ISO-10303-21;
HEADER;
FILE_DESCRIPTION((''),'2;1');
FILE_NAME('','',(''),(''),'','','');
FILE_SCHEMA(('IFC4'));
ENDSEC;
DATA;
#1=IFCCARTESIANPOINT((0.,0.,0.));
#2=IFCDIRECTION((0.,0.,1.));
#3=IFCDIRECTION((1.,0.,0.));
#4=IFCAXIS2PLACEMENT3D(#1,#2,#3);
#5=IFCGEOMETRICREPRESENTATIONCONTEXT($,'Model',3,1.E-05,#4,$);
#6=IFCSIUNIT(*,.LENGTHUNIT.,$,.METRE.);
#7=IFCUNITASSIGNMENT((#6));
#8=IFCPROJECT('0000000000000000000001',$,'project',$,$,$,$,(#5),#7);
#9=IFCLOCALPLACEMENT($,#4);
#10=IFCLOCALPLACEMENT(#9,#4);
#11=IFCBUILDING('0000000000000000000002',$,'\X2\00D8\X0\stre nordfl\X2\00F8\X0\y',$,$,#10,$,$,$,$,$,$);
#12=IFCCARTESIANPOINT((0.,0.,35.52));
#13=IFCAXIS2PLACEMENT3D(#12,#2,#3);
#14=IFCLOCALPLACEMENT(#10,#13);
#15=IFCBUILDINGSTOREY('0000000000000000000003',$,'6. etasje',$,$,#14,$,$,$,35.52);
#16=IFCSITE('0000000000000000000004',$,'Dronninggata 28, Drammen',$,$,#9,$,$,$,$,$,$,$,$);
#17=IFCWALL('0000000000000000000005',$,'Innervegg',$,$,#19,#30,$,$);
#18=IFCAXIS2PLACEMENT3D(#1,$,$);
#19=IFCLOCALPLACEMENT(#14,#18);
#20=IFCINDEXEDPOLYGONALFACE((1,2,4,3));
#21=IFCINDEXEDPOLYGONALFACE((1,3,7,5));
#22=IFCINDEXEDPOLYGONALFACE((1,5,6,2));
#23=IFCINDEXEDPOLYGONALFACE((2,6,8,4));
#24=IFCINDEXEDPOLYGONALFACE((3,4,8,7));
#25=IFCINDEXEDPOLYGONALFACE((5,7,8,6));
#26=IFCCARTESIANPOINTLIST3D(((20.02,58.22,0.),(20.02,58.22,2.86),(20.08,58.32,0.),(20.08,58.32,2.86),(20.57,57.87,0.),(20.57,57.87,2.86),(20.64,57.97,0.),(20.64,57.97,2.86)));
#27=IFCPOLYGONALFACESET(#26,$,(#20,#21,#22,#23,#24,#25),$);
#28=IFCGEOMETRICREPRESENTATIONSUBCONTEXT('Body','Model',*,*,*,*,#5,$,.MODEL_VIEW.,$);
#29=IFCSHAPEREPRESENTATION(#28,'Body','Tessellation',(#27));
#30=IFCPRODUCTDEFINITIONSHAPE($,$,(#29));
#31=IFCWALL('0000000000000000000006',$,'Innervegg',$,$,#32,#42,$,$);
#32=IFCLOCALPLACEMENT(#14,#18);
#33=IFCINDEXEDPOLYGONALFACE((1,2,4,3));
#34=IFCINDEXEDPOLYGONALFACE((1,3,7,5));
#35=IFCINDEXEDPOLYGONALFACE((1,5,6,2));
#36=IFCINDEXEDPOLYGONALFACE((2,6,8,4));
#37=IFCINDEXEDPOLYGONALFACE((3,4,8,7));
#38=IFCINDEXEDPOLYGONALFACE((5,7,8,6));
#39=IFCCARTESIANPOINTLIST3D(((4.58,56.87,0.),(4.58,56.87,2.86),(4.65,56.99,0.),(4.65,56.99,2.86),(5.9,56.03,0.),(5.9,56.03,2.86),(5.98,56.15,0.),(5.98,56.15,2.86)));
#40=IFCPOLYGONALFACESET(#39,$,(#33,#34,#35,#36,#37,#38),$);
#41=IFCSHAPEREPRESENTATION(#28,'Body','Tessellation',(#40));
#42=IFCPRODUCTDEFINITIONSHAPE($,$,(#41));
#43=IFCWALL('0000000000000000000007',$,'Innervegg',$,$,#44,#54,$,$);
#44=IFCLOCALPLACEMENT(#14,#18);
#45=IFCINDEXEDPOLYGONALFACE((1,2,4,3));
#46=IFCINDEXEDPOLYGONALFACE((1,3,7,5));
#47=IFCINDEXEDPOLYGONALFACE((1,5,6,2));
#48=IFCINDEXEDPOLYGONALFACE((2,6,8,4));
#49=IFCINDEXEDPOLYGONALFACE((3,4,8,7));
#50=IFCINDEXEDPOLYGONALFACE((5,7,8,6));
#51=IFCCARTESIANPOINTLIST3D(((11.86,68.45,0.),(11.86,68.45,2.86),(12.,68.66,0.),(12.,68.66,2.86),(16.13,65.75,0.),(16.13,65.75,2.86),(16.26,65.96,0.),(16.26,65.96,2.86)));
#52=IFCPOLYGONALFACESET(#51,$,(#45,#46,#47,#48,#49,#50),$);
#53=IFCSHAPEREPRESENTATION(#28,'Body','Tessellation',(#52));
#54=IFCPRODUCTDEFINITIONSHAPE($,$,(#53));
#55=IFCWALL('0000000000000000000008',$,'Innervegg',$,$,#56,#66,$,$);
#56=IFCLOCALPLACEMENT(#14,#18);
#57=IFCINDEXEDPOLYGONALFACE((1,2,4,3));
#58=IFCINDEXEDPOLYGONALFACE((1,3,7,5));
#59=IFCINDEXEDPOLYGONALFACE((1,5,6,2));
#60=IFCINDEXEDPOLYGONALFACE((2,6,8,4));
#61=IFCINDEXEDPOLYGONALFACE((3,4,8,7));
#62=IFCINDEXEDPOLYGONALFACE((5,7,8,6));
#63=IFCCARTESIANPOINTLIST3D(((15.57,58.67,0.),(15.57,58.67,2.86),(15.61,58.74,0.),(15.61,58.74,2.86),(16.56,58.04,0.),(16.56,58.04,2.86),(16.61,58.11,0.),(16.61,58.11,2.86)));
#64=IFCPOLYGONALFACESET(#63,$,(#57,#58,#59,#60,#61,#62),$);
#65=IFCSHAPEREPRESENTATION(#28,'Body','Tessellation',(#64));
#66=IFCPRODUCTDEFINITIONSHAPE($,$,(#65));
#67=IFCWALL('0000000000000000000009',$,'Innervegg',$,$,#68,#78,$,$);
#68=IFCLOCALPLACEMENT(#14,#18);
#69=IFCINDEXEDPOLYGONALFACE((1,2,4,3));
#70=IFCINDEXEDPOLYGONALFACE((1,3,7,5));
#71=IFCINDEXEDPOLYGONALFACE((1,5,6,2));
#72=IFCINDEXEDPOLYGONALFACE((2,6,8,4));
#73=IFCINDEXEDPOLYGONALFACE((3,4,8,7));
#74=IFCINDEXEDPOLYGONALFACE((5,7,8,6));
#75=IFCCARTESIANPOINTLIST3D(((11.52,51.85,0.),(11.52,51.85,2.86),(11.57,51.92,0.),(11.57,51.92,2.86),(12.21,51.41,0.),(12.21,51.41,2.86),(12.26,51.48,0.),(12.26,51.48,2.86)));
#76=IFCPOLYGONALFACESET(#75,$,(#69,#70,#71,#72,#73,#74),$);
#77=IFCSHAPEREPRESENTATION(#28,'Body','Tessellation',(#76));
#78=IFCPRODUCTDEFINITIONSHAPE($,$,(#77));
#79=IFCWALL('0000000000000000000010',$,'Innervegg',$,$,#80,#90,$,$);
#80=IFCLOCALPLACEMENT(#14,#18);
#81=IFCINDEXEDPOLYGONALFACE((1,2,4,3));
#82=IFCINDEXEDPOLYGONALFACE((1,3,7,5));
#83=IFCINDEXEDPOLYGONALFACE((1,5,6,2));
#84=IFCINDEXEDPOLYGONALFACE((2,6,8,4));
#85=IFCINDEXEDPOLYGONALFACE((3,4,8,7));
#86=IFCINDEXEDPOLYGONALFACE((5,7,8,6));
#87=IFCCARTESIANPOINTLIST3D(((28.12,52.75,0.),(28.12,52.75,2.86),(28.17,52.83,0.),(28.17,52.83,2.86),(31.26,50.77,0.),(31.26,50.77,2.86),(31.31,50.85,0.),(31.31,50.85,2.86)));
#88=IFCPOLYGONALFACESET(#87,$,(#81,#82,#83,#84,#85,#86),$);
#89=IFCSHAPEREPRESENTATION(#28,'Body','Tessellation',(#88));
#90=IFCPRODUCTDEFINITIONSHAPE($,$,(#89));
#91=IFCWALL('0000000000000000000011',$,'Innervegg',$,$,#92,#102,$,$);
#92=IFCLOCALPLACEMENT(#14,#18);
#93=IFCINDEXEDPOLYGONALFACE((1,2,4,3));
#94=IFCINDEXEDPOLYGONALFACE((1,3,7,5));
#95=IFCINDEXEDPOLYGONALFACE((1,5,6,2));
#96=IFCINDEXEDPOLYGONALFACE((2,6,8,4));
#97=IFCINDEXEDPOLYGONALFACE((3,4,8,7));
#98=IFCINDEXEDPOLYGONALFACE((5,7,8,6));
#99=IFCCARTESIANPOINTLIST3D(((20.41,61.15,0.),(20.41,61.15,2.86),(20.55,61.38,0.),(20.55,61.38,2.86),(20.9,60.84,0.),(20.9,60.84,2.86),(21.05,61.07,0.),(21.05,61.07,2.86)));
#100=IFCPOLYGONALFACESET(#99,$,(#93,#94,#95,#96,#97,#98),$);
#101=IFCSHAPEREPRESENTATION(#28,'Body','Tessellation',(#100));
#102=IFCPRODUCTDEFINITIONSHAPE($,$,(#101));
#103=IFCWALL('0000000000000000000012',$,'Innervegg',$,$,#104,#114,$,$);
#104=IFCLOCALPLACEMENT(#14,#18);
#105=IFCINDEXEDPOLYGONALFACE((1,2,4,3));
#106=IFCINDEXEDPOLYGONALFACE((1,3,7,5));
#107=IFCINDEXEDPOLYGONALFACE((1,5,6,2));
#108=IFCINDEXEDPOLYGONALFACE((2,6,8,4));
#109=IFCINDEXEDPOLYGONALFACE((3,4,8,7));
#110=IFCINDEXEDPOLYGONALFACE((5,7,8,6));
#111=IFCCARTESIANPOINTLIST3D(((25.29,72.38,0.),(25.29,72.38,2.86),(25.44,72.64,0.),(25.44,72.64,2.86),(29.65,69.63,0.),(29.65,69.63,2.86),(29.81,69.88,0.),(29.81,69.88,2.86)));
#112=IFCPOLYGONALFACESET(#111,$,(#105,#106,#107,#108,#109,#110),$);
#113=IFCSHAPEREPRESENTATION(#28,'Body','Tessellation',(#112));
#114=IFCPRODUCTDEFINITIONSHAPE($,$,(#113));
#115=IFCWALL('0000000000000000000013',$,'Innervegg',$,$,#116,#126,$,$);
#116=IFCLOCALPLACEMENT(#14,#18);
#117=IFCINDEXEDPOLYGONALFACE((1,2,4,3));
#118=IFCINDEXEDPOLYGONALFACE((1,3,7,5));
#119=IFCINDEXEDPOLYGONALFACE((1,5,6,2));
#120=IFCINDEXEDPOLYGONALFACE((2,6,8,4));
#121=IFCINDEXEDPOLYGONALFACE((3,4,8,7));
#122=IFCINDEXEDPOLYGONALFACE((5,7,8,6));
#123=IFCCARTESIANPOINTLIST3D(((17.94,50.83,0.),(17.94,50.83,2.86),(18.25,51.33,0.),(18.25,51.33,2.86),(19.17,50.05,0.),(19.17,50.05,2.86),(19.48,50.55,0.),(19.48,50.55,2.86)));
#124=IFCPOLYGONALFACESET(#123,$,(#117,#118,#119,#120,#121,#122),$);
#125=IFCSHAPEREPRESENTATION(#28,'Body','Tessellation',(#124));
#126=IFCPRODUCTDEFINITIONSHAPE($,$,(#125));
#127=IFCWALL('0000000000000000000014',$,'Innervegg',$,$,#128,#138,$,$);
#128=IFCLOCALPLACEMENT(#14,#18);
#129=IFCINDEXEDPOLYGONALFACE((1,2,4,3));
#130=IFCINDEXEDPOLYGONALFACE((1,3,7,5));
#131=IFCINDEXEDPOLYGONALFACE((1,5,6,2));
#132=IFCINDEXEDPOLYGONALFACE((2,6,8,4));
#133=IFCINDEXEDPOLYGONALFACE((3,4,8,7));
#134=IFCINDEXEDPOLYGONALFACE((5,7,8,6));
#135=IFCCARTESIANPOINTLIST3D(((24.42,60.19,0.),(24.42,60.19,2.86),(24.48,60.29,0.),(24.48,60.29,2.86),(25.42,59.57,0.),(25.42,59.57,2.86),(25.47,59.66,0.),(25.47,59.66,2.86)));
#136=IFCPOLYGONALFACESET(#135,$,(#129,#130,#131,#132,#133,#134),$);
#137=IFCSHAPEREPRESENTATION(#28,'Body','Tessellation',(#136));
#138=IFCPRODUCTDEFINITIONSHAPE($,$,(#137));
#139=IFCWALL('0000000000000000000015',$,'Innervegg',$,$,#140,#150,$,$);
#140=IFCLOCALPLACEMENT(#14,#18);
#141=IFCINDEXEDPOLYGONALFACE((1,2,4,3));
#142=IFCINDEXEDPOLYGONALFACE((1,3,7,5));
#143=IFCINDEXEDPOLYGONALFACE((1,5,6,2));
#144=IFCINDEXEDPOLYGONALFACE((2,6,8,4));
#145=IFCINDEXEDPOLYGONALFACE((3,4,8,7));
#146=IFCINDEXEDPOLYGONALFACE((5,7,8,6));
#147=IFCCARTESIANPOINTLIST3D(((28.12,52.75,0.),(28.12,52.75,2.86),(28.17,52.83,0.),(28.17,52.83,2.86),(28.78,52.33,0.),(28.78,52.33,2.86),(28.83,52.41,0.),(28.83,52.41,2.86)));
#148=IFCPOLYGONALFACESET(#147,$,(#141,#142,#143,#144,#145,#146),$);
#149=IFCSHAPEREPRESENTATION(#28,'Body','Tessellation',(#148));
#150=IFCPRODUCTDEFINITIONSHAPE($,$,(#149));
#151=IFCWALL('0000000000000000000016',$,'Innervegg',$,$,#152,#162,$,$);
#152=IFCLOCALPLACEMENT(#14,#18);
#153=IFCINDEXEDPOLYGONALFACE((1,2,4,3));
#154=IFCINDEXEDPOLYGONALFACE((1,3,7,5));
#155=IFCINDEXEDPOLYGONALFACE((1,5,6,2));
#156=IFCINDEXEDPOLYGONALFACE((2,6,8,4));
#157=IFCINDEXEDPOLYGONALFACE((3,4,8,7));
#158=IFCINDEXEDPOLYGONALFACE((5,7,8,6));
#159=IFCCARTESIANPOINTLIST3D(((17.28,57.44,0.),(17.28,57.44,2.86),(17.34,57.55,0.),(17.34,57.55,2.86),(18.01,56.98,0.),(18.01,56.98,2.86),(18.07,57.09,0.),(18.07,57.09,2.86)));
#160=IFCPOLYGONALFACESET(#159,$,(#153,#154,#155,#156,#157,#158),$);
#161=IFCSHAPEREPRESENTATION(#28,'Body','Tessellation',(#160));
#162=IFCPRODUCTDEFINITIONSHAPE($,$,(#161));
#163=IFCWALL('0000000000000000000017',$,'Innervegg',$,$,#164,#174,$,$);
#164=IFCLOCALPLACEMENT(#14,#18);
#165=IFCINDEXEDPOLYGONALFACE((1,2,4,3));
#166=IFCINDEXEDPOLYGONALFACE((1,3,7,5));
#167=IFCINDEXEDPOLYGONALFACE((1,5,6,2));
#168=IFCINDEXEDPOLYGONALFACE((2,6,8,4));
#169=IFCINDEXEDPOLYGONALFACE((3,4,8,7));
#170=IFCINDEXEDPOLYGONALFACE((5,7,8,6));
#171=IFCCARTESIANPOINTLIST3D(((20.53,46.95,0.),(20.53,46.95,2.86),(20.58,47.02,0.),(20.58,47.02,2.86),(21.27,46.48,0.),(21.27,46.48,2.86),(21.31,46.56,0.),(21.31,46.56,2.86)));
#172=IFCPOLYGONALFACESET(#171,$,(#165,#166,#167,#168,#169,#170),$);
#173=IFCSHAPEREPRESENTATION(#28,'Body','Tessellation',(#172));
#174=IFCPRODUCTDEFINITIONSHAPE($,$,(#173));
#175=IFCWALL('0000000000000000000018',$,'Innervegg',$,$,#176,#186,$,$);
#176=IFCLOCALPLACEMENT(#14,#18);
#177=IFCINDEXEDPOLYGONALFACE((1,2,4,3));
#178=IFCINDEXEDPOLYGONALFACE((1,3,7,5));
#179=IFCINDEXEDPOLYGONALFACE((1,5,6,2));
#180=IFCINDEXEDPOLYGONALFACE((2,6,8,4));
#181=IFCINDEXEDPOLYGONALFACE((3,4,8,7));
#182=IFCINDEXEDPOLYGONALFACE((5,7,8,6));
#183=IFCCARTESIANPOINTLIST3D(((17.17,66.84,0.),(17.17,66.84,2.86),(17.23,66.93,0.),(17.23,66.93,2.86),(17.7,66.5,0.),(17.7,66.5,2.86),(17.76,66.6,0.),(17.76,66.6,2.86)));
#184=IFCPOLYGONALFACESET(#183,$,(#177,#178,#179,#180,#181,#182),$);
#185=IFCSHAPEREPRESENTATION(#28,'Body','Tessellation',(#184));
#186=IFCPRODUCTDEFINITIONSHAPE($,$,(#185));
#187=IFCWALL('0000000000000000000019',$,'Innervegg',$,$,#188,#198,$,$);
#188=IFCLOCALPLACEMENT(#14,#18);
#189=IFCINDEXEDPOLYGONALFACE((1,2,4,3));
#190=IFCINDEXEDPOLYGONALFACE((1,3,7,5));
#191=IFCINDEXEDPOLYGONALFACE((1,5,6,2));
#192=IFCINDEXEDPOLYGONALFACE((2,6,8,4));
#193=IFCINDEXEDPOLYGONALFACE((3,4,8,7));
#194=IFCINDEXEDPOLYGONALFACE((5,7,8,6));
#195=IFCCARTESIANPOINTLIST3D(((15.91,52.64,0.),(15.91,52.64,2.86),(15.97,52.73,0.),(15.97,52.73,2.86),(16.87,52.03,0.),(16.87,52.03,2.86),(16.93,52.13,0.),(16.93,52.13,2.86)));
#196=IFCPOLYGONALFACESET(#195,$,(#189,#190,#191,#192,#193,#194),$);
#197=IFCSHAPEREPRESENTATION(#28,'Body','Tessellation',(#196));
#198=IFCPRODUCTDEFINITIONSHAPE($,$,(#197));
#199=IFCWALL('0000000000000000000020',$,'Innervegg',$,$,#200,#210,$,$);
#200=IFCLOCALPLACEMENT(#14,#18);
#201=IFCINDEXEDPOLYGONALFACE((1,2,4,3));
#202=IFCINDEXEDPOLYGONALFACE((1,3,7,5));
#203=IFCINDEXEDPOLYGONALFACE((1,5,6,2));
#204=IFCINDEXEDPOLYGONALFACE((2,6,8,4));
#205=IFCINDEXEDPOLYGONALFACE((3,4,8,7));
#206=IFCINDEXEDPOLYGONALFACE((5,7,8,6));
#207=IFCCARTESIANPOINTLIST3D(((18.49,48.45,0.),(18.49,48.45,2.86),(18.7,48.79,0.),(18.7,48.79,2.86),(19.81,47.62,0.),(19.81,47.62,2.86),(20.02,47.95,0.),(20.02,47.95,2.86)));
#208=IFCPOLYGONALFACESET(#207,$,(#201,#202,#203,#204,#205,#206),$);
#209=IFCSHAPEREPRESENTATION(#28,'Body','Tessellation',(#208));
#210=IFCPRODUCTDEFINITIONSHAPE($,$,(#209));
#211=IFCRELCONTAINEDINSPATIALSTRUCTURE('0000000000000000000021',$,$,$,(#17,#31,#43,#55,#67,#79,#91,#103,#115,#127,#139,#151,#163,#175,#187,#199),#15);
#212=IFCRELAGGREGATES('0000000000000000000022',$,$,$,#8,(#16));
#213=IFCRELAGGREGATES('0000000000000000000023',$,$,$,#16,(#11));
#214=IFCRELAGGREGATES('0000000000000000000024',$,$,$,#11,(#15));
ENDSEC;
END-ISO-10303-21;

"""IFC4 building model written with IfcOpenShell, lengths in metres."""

from ifc_helpers import new_model, si_unit, frame, origin_with_axes, place, context, subcontext, project, spatial, polyline, outline, extrude, element, save


model = new_model("IFC4")

# Units and contexts
model_context = context("Model", 3, precision=1e-05, world=origin_with_axes())
body_context = subcontext(model_context, "Body", "Model", "MODEL_VIEW")
ifc_project = project(units=[si_unit("LENGTHUNIT", "METRE")], contexts=[model_context])

# Site, building, storey
site_placement = place(None, origin_with_axes())
site = spatial("IfcSite", under=ifc_project, at=site_placement, Name="Dronninggata 28, Drammen")
building_placement = place(site_placement, origin_with_axes())
building = spatial("IfcBuilding", under=site, at=building_placement, Name="Østre nordfløy")
storey_placement = place(building_placement, frame((0.0, 0.0, 35.52), z_axis=(0.0, 0.0, 1.0), x_axis=(1.0, 0.0, 0.0)))
storey = spatial("IfcBuildingStorey", under=building, at=storey_placement, Name="6. etasje", Elevation=35.52)

# Walls
wall_1_placement = place(storey_placement, frame((0.0, 0.0, -35.52), z_axis=(0.0, 0.0, 1.0), x_axis=(1.0, 0.0, 0.0)))
element("IfcWall", 1, at=wall_1_placement, inside=storey, Name="Innervegg", context=body_context, shape_type="SweptSolid", body=[
    extrude(outline(polyline([(20.64, 57.97), (20.57, 57.87), (20.02, 58.22), (20.08, 58.32), (20.64, 57.97)])), frame((0.0, 0.0, 35.52)), (0.0, 0.0, 1.0), 2.86),
])
wall_2_placement = place(storey_placement, frame((0.0, 0.0, -35.52), z_axis=(0.0, 0.0, 1.0), x_axis=(1.0, 0.0, 0.0)))
element("IfcWall", 2, at=wall_2_placement, inside=storey, Name="Innervegg", context=body_context, shape_type="SweptSolid", body=[
    extrude(outline(polyline([(5.98, 56.15), (5.9, 56.03), (4.58, 56.87), (4.65, 56.99), (5.98, 56.15)])), frame((0.0, 0.0, 35.52)), (0.0, 0.0, 1.0), 2.86),
])
wall_3_placement = place(storey_placement, frame((0.0, 0.0, -35.52), z_axis=(0.0, 0.0, 1.0), x_axis=(1.0, 0.0, 0.0)))
element("IfcWall", 3, at=wall_3_placement, inside=storey, Name="Innervegg", context=body_context, shape_type="SweptSolid", body=[
    extrude(outline(polyline([(16.26, 65.96), (16.13, 65.75), (11.86, 68.45), (12.0, 68.66), (16.26, 65.96)])), frame((0.0, 0.0, 35.52)), (0.0, 0.0, 1.0), 2.86),
])
wall_4_placement = place(storey_placement, frame((0.0, 0.0, -35.52), z_axis=(0.0, 0.0, 1.0), x_axis=(1.0, 0.0, 0.0)))
element("IfcWall", 4, at=wall_4_placement, inside=storey, Name="Innervegg", context=body_context, shape_type="SweptSolid", body=[
    extrude(outline(polyline([(16.61, 58.11), (16.56, 58.04), (15.57, 58.67), (15.61, 58.74), (16.61, 58.11)])), frame((0.0, 0.0, 35.52)), (0.0, 0.0, 1.0), 2.86),
])
wall_5_placement = place(storey_placement, frame((0.0, 0.0, -35.52), z_axis=(0.0, 0.0, 1.0), x_axis=(1.0, 0.0, 0.0)))
element("IfcWall", 5, at=wall_5_placement, inside=storey, Name="Innervegg", context=body_context, shape_type="SweptSolid", body=[
    extrude(outline(polyline([(12.26, 51.48), (12.21, 51.41), (11.52, 51.85), (11.57, 51.92), (12.26, 51.48)])), frame((0.0, 0.0, 35.52)), (0.0, 0.0, 1.0), 2.86),
])
wall_6_placement = place(storey_placement, frame((0.0, 0.0, -35.52), z_axis=(0.0, 0.0, 1.0), x_axis=(1.0, 0.0, 0.0)))
element("IfcWall", 6, at=wall_6_placement, inside=storey, Name="Innervegg", context=body_context, shape_type="SweptSolid", body=[
    extrude(outline(polyline([(31.31, 50.85), (31.26, 50.77), (28.12, 52.75), (28.17, 52.83), (31.31, 50.85)])), frame((0.0, 0.0, 35.52)), (0.0, 0.0, 1.0), 2.86),
])
wall_7_placement = place(storey_placement, frame((0.0, 0.0, -35.52), z_axis=(0.0, 0.0, 1.0), x_axis=(1.0, 0.0, 0.0)))
element("IfcWall", 7, at=wall_7_placement, inside=storey, Name="Innervegg", context=body_context, shape_type="SweptSolid", body=[
    extrude(outline(polyline([(21.05, 61.07), (20.9, 60.84), (20.41, 61.15), (20.55, 61.38), (21.05, 61.07)])), frame((0.0, 0.0, 35.52)), (0.0, 0.0, 1.0), 2.86),
])
wall_8_placement = place(storey_placement, frame((0.0, 0.0, -35.52), z_axis=(0.0, 0.0, 1.0), x_axis=(1.0, 0.0, 0.0)))
element("IfcWall", 8, at=wall_8_placement, inside=storey, Name="Innervegg", context=body_context, shape_type="SweptSolid", body=[
    extrude(outline(polyline([(29.81, 69.88), (29.65, 69.63), (25.29, 72.38), (25.44, 72.64), (29.81, 69.88)])), frame((0.0, 0.0, 35.52)), (0.0, 0.0, 1.0), 2.86),
])
wall_9_placement = place(storey_placement, frame((0.0, 0.0, -35.52), z_axis=(0.0, 0.0, 1.0), x_axis=(1.0, 0.0, 0.0)))
element("IfcWall", 9, at=wall_9_placement, inside=storey, Name="Innervegg", context=body_context, shape_type="SweptSolid", body=[
    extrude(outline(polyline([(19.48, 50.55), (19.17, 50.05), (17.94, 50.83), (18.25, 51.33), (19.48, 50.55)])), frame((0.0, 0.0, 35.52)), (0.0, 0.0, 1.0), 2.86),
])
wall_10_placement = place(storey_placement, frame((0.0, 0.0, -35.52), z_axis=(0.0, 0.0, 1.0), x_axis=(1.0, 0.0, 0.0)))
element("IfcWall", 10, at=wall_10_placement, inside=storey, Name="Innervegg", context=body_context, shape_type="SweptSolid", body=[
    extrude(outline(polyline([(25.47, 59.66), (25.42, 59.57), (24.42, 60.19), (24.48, 60.29), (25.47, 59.66)])), frame((0.0, 0.0, 35.52)), (0.0, 0.0, 1.0), 2.86),
])
wall_11_placement = place(storey_placement, frame((0.0, 0.0, -35.52), z_axis=(0.0, 0.0, 1.0), x_axis=(1.0, 0.0, 0.0)))
element("IfcWall", 11, at=wall_11_placement, inside=storey, Name="Innervegg", context=body_context, shape_type="SweptSolid", body=[
    extrude(outline(polyline([(28.83, 52.41), (28.78, 52.33), (28.12, 52.75), (28.17, 52.83), (28.83, 52.41)])), frame((0.0, 0.0, 35.52)), (0.0, 0.0, 1.0), 2.86),
])
wall_12_placement = place(storey_placement, frame((0.0, 0.0, -35.52), z_axis=(0.0, 0.0, 1.0), x_axis=(1.0, 0.0, 0.0)))
element("IfcWall", 12, at=wall_12_placement, inside=storey, Name="Innervegg", context=body_context, shape_type="SweptSolid", body=[
    extrude(outline(polyline([(18.07, 57.09), (18.01, 56.98), (17.28, 57.44), (17.34, 57.55), (18.07, 57.09)])), frame((0.0, 0.0, 35.52)), (0.0, 0.0, 1.0), 2.86),
])
wall_13_placement = place(storey_placement, frame((0.0, 0.0, -35.52), z_axis=(0.0, 0.0, 1.0), x_axis=(1.0, 0.0, 0.0)))
element("IfcWall", 13, at=wall_13_placement, inside=storey, Name="Innervegg", context=body_context, shape_type="SweptSolid", body=[
    extrude(outline(polyline([(21.31, 46.56), (21.27, 46.48), (20.53, 46.95), (20.58, 47.02), (21.31, 46.56)])), frame((0.0, 0.0, 35.52)), (0.0, 0.0, 1.0), 2.86),
])
wall_14_placement = place(storey_placement, frame((0.0, 0.0, -35.52), z_axis=(0.0, 0.0, 1.0), x_axis=(1.0, 0.0, 0.0)))
element("IfcWall", 14, at=wall_14_placement, inside=storey, Name="Innervegg", context=body_context, shape_type="SweptSolid", body=[
    extrude(outline(polyline([(17.76, 66.6), (17.7, 66.5), (17.17, 66.84), (17.23, 66.93), (17.76, 66.6)])), frame((0.0, 0.0, 35.52)), (0.0, 0.0, 1.0), 2.86),
])
wall_15_placement = place(storey_placement, frame((0.0, 0.0, -35.52), z_axis=(0.0, 0.0, 1.0), x_axis=(1.0, 0.0, 0.0)))
element("IfcWall", 15, at=wall_15_placement, inside=storey, Name="Innervegg", context=body_context, shape_type="SweptSolid", body=[
    extrude(outline(polyline([(16.93, 52.13), (16.87, 52.03), (15.91, 52.64), (15.97, 52.73), (16.93, 52.13)])), frame((0.0, 0.0, 35.52)), (0.0, 0.0, 1.0), 2.86),
])
wall_16_placement = place(storey_placement, frame((0.0, 0.0, -35.52), z_axis=(0.0, 0.0, 1.0), x_axis=(1.0, 0.0, 0.0)))
element("IfcWall", 16, at=wall_16_placement, inside=storey, Name="Innervegg", context=body_context, shape_type="SweptSolid", body=[
    extrude(outline(polyline([(20.02, 47.95), (19.81, 47.62), (18.49, 48.45), (18.7, 48.79), (20.02, 47.95)])), frame((0.0, 0.0, 35.52)), (0.0, 0.0, 1.0), 2.86),
])

save(model, "model.ifc")
